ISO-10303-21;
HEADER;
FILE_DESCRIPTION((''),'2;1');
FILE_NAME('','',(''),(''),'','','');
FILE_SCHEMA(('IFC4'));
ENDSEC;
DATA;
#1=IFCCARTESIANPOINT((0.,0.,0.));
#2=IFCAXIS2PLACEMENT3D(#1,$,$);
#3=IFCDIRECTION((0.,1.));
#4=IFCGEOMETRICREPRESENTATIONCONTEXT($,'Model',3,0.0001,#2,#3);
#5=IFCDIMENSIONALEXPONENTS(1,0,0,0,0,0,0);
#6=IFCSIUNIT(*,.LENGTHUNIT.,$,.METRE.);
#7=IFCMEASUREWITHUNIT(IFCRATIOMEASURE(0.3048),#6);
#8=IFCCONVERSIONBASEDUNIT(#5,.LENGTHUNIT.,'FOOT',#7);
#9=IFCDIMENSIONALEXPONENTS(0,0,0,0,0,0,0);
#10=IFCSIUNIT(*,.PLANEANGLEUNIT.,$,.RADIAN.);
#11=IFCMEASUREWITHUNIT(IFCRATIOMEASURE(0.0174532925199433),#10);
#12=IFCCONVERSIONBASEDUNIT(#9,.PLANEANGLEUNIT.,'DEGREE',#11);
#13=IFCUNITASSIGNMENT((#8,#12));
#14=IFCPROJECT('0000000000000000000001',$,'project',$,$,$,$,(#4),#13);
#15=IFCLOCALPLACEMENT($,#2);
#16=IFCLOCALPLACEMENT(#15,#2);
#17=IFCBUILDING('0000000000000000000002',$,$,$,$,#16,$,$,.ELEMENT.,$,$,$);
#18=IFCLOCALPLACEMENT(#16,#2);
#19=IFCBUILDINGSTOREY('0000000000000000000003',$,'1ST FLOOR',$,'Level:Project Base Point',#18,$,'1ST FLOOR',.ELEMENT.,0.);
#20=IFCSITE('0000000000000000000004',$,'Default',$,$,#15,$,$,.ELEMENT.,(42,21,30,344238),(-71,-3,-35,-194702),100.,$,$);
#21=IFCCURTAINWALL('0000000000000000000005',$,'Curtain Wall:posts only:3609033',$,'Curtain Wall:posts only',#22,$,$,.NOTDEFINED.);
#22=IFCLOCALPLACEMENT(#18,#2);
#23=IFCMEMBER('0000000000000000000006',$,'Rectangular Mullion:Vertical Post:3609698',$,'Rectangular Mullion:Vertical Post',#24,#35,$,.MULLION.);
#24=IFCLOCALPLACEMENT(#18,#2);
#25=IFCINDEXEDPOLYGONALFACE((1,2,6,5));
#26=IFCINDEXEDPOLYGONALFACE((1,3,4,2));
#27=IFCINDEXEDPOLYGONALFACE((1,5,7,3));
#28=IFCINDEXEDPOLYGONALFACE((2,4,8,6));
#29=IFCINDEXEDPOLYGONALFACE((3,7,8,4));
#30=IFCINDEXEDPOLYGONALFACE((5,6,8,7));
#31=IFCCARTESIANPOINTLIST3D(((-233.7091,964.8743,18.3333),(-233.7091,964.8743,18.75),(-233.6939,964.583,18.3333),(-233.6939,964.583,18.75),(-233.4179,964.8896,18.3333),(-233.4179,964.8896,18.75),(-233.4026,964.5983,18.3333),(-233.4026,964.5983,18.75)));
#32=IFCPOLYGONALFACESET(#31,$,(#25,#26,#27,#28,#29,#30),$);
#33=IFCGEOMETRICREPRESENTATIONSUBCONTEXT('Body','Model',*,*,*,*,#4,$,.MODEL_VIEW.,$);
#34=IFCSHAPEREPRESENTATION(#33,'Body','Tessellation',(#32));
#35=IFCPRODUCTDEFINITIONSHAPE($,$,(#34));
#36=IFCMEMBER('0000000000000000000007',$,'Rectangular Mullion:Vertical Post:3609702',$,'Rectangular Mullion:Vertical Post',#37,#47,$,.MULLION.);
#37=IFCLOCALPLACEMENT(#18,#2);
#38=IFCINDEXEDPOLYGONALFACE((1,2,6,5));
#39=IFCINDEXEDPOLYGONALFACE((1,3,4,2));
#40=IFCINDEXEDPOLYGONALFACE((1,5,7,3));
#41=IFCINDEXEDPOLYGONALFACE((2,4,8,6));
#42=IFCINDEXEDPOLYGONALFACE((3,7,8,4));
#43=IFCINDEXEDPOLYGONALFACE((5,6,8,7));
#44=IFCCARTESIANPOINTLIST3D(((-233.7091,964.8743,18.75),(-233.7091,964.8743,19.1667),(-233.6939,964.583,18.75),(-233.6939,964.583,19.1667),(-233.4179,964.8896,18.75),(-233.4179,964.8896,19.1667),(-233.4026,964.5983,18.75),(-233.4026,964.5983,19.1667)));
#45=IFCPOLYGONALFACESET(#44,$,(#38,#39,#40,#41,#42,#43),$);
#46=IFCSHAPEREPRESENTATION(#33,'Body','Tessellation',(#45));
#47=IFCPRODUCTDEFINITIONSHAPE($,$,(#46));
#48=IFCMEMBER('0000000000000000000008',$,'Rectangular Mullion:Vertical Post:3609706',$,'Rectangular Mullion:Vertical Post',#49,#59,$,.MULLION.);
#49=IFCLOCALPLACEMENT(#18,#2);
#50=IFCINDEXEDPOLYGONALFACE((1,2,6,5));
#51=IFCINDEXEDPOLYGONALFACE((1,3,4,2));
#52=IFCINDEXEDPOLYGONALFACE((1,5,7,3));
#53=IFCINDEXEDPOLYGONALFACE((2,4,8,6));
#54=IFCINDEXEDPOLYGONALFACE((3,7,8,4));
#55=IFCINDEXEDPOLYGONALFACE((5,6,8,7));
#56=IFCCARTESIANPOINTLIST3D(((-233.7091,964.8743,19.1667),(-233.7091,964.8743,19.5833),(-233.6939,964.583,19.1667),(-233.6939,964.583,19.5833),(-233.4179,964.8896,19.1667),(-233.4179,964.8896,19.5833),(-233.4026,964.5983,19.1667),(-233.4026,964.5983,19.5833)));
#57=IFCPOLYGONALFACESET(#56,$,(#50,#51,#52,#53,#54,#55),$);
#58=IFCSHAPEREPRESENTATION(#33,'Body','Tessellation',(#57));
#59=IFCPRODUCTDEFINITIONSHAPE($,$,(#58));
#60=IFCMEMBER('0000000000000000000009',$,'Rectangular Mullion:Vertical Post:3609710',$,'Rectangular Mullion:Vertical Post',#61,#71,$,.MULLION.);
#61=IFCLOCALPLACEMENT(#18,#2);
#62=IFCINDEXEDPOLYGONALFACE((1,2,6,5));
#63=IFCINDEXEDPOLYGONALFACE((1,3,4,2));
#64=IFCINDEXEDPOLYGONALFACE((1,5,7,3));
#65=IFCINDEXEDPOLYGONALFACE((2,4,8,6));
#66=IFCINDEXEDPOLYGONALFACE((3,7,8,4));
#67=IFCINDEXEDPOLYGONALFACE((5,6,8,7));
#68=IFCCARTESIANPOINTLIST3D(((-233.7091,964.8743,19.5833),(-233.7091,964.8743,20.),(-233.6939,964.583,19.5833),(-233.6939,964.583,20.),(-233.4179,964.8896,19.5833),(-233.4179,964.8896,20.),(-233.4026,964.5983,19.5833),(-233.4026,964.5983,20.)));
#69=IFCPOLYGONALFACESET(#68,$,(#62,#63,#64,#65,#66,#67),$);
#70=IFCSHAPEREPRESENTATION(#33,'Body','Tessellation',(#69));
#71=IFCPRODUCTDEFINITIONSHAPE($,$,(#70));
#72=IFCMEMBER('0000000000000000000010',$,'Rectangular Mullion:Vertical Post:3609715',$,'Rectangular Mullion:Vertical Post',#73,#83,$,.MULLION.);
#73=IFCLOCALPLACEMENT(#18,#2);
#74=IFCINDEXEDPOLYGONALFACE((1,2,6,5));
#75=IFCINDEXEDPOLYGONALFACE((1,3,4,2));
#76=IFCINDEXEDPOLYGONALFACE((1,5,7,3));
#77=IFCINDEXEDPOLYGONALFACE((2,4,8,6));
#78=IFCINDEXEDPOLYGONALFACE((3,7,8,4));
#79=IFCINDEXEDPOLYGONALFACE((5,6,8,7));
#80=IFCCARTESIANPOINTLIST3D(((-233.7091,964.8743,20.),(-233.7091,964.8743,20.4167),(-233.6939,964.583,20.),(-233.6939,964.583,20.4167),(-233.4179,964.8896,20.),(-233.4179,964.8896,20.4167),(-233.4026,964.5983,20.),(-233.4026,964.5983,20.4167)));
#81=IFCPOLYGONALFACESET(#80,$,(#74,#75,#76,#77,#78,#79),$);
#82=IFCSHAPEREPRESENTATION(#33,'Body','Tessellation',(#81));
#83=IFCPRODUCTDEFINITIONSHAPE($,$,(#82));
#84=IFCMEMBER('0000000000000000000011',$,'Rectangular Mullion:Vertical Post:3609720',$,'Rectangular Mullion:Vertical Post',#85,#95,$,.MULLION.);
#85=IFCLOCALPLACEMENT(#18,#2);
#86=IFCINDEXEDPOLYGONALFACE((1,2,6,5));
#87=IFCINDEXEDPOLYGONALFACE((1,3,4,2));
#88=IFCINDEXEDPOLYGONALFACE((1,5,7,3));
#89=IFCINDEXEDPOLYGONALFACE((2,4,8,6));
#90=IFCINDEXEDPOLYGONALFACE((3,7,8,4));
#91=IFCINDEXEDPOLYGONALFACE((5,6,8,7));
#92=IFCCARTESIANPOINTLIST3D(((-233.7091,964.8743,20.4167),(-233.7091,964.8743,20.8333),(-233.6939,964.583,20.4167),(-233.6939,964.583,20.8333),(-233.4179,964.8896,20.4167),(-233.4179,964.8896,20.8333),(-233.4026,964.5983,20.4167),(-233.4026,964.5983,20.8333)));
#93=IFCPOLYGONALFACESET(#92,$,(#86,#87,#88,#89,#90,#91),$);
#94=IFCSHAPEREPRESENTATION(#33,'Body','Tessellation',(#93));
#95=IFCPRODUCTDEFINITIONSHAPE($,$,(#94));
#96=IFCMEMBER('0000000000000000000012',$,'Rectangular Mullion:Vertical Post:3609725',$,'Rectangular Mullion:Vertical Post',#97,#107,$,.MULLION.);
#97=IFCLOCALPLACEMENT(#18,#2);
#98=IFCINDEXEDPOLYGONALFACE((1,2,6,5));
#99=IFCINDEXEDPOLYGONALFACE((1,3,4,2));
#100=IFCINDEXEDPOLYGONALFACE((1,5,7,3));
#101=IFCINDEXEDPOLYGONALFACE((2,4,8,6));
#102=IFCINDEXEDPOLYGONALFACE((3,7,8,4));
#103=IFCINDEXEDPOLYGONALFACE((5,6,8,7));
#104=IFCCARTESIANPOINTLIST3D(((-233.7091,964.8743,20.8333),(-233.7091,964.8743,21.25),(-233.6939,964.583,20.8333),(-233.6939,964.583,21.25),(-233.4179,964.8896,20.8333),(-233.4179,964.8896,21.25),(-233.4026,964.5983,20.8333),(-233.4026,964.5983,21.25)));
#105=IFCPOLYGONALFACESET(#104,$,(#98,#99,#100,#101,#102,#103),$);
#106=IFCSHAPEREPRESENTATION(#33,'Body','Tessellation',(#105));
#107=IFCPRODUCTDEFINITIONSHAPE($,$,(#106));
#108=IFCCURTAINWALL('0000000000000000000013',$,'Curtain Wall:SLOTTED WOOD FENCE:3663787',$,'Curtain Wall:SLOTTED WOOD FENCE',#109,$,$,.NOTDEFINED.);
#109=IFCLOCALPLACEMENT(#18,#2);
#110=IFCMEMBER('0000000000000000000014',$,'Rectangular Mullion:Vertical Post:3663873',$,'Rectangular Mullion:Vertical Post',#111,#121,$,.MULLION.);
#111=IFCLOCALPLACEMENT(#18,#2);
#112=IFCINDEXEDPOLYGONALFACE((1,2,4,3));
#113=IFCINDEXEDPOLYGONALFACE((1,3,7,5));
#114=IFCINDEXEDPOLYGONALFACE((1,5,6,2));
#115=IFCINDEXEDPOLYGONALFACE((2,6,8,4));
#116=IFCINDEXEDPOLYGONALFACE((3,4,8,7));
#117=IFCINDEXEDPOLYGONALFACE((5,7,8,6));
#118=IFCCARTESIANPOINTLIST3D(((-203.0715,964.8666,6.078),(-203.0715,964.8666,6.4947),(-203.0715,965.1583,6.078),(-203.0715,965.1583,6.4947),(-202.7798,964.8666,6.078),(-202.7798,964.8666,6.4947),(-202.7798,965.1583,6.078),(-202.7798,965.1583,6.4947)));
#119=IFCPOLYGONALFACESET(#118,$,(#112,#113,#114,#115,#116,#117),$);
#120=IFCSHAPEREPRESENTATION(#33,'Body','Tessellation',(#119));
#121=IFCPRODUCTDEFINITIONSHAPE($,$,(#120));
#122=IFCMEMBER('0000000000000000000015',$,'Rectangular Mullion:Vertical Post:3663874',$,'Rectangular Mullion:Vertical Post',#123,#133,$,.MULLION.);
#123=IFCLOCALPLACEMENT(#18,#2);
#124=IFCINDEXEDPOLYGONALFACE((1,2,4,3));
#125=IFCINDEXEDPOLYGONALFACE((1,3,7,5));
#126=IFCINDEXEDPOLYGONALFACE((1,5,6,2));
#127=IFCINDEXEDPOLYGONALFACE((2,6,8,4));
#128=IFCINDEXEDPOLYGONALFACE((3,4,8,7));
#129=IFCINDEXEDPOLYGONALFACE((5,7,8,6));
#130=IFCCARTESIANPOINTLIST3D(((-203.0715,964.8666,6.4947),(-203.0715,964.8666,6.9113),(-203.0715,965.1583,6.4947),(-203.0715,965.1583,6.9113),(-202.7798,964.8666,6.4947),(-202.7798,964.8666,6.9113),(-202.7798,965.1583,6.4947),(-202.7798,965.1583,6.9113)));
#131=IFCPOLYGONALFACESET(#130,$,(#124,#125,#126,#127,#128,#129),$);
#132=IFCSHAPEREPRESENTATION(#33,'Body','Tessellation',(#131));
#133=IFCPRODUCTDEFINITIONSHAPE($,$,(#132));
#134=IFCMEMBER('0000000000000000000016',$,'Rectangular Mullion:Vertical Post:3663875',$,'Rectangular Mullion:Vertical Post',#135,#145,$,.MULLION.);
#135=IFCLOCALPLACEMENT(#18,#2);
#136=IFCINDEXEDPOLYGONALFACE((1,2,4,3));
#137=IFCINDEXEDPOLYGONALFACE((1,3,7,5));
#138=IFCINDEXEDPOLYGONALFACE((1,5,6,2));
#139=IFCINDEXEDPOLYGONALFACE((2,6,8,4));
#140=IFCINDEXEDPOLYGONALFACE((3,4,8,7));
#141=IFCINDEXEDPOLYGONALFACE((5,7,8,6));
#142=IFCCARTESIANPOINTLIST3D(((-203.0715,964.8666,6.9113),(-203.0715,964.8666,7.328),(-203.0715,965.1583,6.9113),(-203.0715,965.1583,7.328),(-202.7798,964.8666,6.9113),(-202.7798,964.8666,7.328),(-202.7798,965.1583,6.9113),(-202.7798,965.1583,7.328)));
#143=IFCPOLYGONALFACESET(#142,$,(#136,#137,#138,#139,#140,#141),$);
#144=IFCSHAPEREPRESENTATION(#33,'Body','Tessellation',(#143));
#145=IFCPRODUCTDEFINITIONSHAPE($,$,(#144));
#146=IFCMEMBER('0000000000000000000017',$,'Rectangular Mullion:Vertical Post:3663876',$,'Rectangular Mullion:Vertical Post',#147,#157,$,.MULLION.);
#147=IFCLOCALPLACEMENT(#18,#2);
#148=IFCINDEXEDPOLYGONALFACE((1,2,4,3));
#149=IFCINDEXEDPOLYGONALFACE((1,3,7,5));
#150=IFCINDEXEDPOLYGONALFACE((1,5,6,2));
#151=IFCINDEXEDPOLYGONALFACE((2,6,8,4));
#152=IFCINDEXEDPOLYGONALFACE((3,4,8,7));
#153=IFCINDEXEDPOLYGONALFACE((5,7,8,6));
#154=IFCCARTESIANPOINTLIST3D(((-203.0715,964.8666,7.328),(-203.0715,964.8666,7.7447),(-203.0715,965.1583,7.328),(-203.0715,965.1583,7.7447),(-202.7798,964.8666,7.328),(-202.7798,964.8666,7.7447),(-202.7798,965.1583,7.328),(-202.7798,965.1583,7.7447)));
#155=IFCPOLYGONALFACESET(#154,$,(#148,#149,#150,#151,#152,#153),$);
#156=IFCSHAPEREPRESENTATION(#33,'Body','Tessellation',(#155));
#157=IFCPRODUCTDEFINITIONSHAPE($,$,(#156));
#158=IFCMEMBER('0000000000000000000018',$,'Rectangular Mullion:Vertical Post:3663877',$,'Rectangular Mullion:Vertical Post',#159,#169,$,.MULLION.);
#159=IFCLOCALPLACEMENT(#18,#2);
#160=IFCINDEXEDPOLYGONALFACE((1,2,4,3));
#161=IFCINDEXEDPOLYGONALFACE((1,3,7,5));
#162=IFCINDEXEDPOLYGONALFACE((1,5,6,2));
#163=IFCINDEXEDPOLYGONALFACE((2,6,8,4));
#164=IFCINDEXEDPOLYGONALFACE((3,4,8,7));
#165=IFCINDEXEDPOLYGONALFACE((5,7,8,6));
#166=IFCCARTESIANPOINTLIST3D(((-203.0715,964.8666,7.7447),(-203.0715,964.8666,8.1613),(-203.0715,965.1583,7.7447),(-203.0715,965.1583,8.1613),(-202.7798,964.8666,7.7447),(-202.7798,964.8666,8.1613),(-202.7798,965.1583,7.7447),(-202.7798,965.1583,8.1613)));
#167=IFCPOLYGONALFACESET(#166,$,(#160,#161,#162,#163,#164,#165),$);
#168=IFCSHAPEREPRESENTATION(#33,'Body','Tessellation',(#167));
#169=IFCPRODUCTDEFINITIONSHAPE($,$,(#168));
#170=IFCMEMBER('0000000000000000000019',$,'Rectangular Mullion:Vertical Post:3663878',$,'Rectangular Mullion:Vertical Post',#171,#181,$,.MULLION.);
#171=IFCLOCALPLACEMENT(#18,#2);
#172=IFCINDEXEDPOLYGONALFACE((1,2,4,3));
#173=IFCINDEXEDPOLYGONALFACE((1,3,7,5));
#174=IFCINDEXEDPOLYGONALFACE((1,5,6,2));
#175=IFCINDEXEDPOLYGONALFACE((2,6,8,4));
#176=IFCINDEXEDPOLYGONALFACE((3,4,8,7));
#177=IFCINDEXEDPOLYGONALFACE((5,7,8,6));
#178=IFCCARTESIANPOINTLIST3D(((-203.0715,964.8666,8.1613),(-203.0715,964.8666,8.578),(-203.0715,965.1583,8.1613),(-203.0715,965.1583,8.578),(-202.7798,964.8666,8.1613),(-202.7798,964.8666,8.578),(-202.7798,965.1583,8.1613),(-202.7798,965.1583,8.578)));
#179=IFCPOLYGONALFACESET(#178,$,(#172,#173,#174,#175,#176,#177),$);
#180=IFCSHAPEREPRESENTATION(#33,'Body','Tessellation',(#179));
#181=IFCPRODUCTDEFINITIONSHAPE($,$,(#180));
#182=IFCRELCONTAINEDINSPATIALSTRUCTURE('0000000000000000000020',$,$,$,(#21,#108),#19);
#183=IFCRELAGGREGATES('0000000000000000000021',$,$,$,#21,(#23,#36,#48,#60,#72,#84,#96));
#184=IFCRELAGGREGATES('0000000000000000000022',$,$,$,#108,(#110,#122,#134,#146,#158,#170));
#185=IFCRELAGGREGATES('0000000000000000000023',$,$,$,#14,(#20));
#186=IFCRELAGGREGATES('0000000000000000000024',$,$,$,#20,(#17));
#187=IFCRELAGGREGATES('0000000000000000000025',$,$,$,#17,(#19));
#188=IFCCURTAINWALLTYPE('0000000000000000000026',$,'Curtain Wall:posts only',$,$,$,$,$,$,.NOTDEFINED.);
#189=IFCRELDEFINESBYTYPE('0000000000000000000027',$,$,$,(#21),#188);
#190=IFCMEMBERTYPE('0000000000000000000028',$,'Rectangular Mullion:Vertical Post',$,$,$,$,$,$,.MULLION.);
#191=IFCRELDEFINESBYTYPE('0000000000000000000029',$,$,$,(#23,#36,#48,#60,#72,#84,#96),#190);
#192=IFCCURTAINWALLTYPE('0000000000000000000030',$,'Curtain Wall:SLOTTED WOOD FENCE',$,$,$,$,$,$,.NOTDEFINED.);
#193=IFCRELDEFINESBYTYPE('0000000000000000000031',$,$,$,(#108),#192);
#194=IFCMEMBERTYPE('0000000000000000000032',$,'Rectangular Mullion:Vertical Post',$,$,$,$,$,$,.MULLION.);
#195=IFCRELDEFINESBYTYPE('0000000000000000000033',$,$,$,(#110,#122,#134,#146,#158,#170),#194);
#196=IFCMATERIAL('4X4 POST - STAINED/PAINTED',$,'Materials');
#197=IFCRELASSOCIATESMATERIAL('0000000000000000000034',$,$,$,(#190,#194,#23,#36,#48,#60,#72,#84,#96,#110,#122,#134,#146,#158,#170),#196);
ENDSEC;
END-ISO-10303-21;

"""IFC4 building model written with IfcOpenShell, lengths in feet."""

from ifc_helpers import new_model, entity, si_unit, converted_unit, direction, frame, origin, origin_2d_with_axis, place, context, subcontext, project, spatial, rectangle, extrude, source, transform, mapped, material, material_profile, profile_set, profile_usage, type_object, type_shapes, element, aggregate, save


model = new_model("IFC4")

# Units and contexts
model_context = context("Model", 3, precision=0.0001, world=origin(), true_north=direction((0.0, 1.0)))
body_context = subcontext(model_context, "Body", "Model", "MODEL_VIEW")
ifc_project = project(units=[converted_unit("LENGTHUNIT", "FOOT", entity("IfcRatioMeasure", 0.3048), si_unit("LENGTHUNIT", "METRE"), dimensions=[1, 0, 0, 0, 0, 0, 0]), converted_unit("PLANEANGLEUNIT", "DEGREE", entity("IfcRatioMeasure", 0.0174532925199433), si_unit("PLANEANGLEUNIT", "RADIAN"), dimensions=[0, 0, 0, 0, 0, 0, 0])], contexts=[model_context])

# Site, building, storey
site_placement = place(None, origin())
site = spatial("IfcSite", under=ifc_project, at=site_placement, Name="Default", CompositionType="ELEMENT", RefLatitude=(42, 21, 30, 344238), RefLongitude=(-71, -3, -35, -194702), RefElevation=100.0)
building_placement = place(site_placement, origin())
building = spatial("IfcBuilding", under=site, at=building_placement, CompositionType="ELEMENT")
storey_placement = place(building_placement, origin())
storey = spatial("IfcBuildingStorey", under=building, at=storey_placement, Name="1ST FLOOR", ObjectType="Level:Project Base Point", LongName="1ST FLOOR", CompositionType="ELEMENT", Elevation=0.0)

# Curtain walls, members
curtain_wall_type_1 = type_object("IfcCurtainWallType", Name="Curtain Wall:posts only", PredefinedType="NOTDEFINED")
curtain_wall_1_placement = place(storey_placement, origin())
curtain_wall_1 = element("IfcCurtainWall", 1, at=curtain_wall_1_placement, inside=storey, type_object=curtain_wall_type_1, Name="Curtain Wall:posts only:3609033", ObjectType="Curtain Wall:posts only", PredefinedType="NOTDEFINED")
ifc_material_1 = material(Name="4X4 POST - STAINED/PAINTED", Category="Materials")
ifc_material_profile_1 = material_profile(ifc_material_1, rectangle(XDim=0.2917, YDim=0.2917, at=origin_2d_with_axis()), Name="Vertical Post")
ifc_profile_set_1 = profile_set([ifc_material_profile_1], Name="Vertical Post")
ifc_profile_usage_1 = profile_usage(ifc_profile_set_1)
member_type_1 = type_object("IfcMemberType", Name="Rectangular Mullion:Vertical Post", PredefinedType="MULLION", material=ifc_profile_set_1)
shared_shape_1 = source(origin(), body_context, "Body", "SweptSolid", [
    extrude(rectangle(XDim=0.2917, YDim=0.2917, at=origin_2d_with_axis()), frame((0.0, -0.2083, -0.4167), z_axis=(0.0, 0.0, 1.0), x_axis=(0.0, -1.0, 0.0)), (0.0, 0.0, 1.0), 0.4167),
])
type_shapes(member_type_1, [shared_shape_1])
member_1_placement = place(storey_placement, frame((-233.5668, 964.9443, 18.3333), z_axis=(0.0, 0.0, -1.0), x_axis=(-0.99863, -0.052336, 0.0)))
member_1 = element("IfcMember", 2, at=member_1_placement, type_object=member_type_1, material=ifc_profile_usage_1, Name="Rectangular Mullion:Vertical Post:3609698", ObjectType="Rectangular Mullion:Vertical Post", PredefinedType="MULLION", context=body_context, shape_type="MappedRepresentation", body=[
    mapped(shared_shape_1, transform((0.0, 0.0, 0.0), scale=1.0)),
])
ifc_profile_usage_2 = profile_usage(ifc_profile_set_1)
member_2_placement = place(storey_placement, frame((-233.5668, 964.9443, 18.75), z_axis=(0.0, 0.0, -1.0), x_axis=(-0.99863, -0.052336, 0.0)))
member_2 = element("IfcMember", 3, at=member_2_placement, type_object=member_type_1, material=ifc_profile_usage_2, Name="Rectangular Mullion:Vertical Post:3609702", ObjectType="Rectangular Mullion:Vertical Post", PredefinedType="MULLION", context=body_context, shape_type="MappedRepresentation", body=[
    mapped(shared_shape_1, transform((0.0, 0.0, 0.0), scale=1.0)),
])
ifc_profile_usage_3 = profile_usage(ifc_profile_set_1)
member_3_placement = place(storey_placement, frame((-233.5668, 964.9443, 19.1667), z_axis=(0.0, 0.0, -1.0), x_axis=(-0.99863, -0.052336, 0.0)))
member_3 = element("IfcMember", 4, at=member_3_placement, type_object=member_type_1, material=ifc_profile_usage_3, Name="Rectangular Mullion:Vertical Post:3609706", ObjectType="Rectangular Mullion:Vertical Post", PredefinedType="MULLION", context=body_context, shape_type="MappedRepresentation", body=[
    mapped(shared_shape_1, transform((0.0, 0.0, 0.0), scale=1.0)),
])
ifc_profile_usage_4 = profile_usage(ifc_profile_set_1)
member_4_placement = place(storey_placement, frame((-233.5668, 964.9443, 19.5833), z_axis=(0.0, 0.0, -1.0), x_axis=(-0.99863, -0.052336, 0.0)))
member_4 = element("IfcMember", 5, at=member_4_placement, type_object=member_type_1, material=ifc_profile_usage_4, Name="Rectangular Mullion:Vertical Post:3609710", ObjectType="Rectangular Mullion:Vertical Post", PredefinedType="MULLION", context=body_context, shape_type="MappedRepresentation", body=[
    mapped(shared_shape_1, transform((0.0, 0.0, 0.0), scale=1.0)),
])
ifc_profile_usage_5 = profile_usage(ifc_profile_set_1)
member_5_placement = place(storey_placement, frame((-233.5668, 964.9443, 20.0), z_axis=(0.0, 0.0, -1.0), x_axis=(-0.99863, -0.052336, 0.0)))
member_5 = element("IfcMember", 6, at=member_5_placement, type_object=member_type_1, material=ifc_profile_usage_5, Name="Rectangular Mullion:Vertical Post:3609715", ObjectType="Rectangular Mullion:Vertical Post", PredefinedType="MULLION", context=body_context, shape_type="MappedRepresentation", body=[
    mapped(shared_shape_1, transform((0.0, 0.0, 0.0), scale=1.0)),
])
ifc_profile_usage_6 = profile_usage(ifc_profile_set_1)
member_6_placement = place(storey_placement, frame((-233.5668, 964.9443, 20.4167), z_axis=(0.0, 0.0, -1.0), x_axis=(-0.99863, -0.052336, 0.0)))
member_6 = element("IfcMember", 7, at=member_6_placement, type_object=member_type_1, material=ifc_profile_usage_6, Name="Rectangular Mullion:Vertical Post:3609720", ObjectType="Rectangular Mullion:Vertical Post", PredefinedType="MULLION", context=body_context, shape_type="MappedRepresentation", body=[
    mapped(shared_shape_1, transform((0.0, 0.0, 0.0), scale=1.0)),
])
ifc_profile_usage_7 = profile_usage(ifc_profile_set_1)
member_7_placement = place(storey_placement, frame((-233.5668, 964.9443, 20.8333), z_axis=(0.0, 0.0, -1.0), x_axis=(-0.99863, -0.052336, 0.0)))
member_7 = element("IfcMember", 8, at=member_7_placement, type_object=member_type_1, material=ifc_profile_usage_7, Name="Rectangular Mullion:Vertical Post:3609725", ObjectType="Rectangular Mullion:Vertical Post", PredefinedType="MULLION", context=body_context, shape_type="MappedRepresentation", body=[
    mapped(shared_shape_1, transform((0.0, 0.0, 0.0), scale=1.0)),
])
aggregate(curtain_wall_1, [member_1, member_2, member_3, member_4, member_5, member_6, member_7])
curtain_wall_type_2 = type_object("IfcCurtainWallType", Name="Curtain Wall:SLOTTED WOOD FENCE", PredefinedType="NOTDEFINED")
curtain_wall_2_placement = place(storey_placement, origin())
curtain_wall_2 = element("IfcCurtainWall", 9, at=curtain_wall_2_placement, inside=storey, type_object=curtain_wall_type_2, Name="Curtain Wall:SLOTTED WOOD FENCE:3663787", ObjectType="Curtain Wall:SLOTTED WOOD FENCE", PredefinedType="NOTDEFINED")
ifc_profile_usage_8 = profile_usage(ifc_profile_set_1)
member_type_2 = type_object("IfcMemberType", Name="Rectangular Mullion:Vertical Post", PredefinedType="MULLION", material=ifc_profile_set_1)
shared_shape_2 = source(origin(), body_context, "Body", "SweptSolid", [
    extrude(rectangle(XDim=0.2917, YDim=0.2917, at=origin_2d_with_axis()), frame((-0.1458, -0.2083, -0.4167), z_axis=(0.0, 0.0, 1.0), x_axis=(0.0, -1.0, 0.0)), (0.0, 0.0, 1.0), 0.4167),
])
type_shapes(member_type_2, [shared_shape_2])
member_8_placement = place(storey_placement, frame((-203.134, 964.8666, 6.078), z_axis=(0.0, 0.0, -1.0), x_axis=(0.0, -1.0, 0.0)))
member_8 = element("IfcMember", 10, at=member_8_placement, type_object=member_type_2, material=ifc_profile_usage_8, Name="Rectangular Mullion:Vertical Post:3663873", ObjectType="Rectangular Mullion:Vertical Post", PredefinedType="MULLION", context=body_context, shape_type="MappedRepresentation", body=[
    mapped(shared_shape_2, transform((0.0, 0.0, 0.0), scale=1.0)),
])
ifc_profile_usage_9 = profile_usage(ifc_profile_set_1)
member_9_placement = place(storey_placement, frame((-203.134, 964.8666, 6.4947), z_axis=(0.0, 0.0, -1.0), x_axis=(0.0, -1.0, 0.0)))
member_9 = element("IfcMember", 11, at=member_9_placement, type_object=member_type_2, material=ifc_profile_usage_9, Name="Rectangular Mullion:Vertical Post:3663874", ObjectType="Rectangular Mullion:Vertical Post", PredefinedType="MULLION", context=body_context, shape_type="MappedRepresentation", body=[
    mapped(shared_shape_2, transform((0.0, 0.0, 0.0), scale=1.0)),
])
ifc_profile_usage_10 = profile_usage(ifc_profile_set_1)
member_10_placement = place(storey_placement, frame((-203.134, 964.8666, 6.9113), z_axis=(0.0, 0.0, -1.0), x_axis=(0.0, -1.0, 0.0)))
member_10 = element("IfcMember", 12, at=member_10_placement, type_object=member_type_2, material=ifc_profile_usage_10, Name="Rectangular Mullion:Vertical Post:3663875", ObjectType="Rectangular Mullion:Vertical Post", PredefinedType="MULLION", context=body_context, shape_type="MappedRepresentation", body=[
    mapped(shared_shape_2, transform((0.0, 0.0, 0.0), scale=1.0)),
])
ifc_profile_usage_11 = profile_usage(ifc_profile_set_1)
member_11_placement = place(storey_placement, frame((-203.134, 964.8666, 7.328), z_axis=(0.0, 0.0, -1.0), x_axis=(0.0, -1.0, 0.0)))
member_11 = element("IfcMember", 13, at=member_11_placement, type_object=member_type_2, material=ifc_profile_usage_11, Name="Rectangular Mullion:Vertical Post:3663876", ObjectType="Rectangular Mullion:Vertical Post", PredefinedType="MULLION", context=body_context, shape_type="MappedRepresentation", body=[
    mapped(shared_shape_2, transform((0.0, 0.0, 0.0), scale=1.0)),
])
ifc_profile_usage_12 = profile_usage(ifc_profile_set_1)
member_12_placement = place(storey_placement, frame((-203.134, 964.8666, 7.7447), z_axis=(0.0, 0.0, -1.0), x_axis=(0.0, -1.0, 0.0)))
member_12 = element("IfcMember", 14, at=member_12_placement, type_object=member_type_2, material=ifc_profile_usage_12, Name="Rectangular Mullion:Vertical Post:3663877", ObjectType="Rectangular Mullion:Vertical Post", PredefinedType="MULLION", context=body_context, shape_type="MappedRepresentation", body=[
    mapped(shared_shape_2, transform((0.0, 0.0, 0.0), scale=1.0)),
])
ifc_profile_usage_13 = profile_usage(ifc_profile_set_1)
member_13_placement = place(storey_placement, frame((-203.134, 964.8666, 8.1613), z_axis=(0.0, 0.0, -1.0), x_axis=(0.0, -1.0, 0.0)))
member_13 = element("IfcMember", 15, at=member_13_placement, type_object=member_type_2, material=ifc_profile_usage_13, Name="Rectangular Mullion:Vertical Post:3663878", ObjectType="Rectangular Mullion:Vertical Post", PredefinedType="MULLION", context=body_context, shape_type="MappedRepresentation", body=[
    mapped(shared_shape_2, transform((0.0, 0.0, 0.0), scale=1.0)),
])
aggregate(curtain_wall_2, [member_8, member_9, member_10, member_11, member_12, member_13])

save(model, "model.ifc")
